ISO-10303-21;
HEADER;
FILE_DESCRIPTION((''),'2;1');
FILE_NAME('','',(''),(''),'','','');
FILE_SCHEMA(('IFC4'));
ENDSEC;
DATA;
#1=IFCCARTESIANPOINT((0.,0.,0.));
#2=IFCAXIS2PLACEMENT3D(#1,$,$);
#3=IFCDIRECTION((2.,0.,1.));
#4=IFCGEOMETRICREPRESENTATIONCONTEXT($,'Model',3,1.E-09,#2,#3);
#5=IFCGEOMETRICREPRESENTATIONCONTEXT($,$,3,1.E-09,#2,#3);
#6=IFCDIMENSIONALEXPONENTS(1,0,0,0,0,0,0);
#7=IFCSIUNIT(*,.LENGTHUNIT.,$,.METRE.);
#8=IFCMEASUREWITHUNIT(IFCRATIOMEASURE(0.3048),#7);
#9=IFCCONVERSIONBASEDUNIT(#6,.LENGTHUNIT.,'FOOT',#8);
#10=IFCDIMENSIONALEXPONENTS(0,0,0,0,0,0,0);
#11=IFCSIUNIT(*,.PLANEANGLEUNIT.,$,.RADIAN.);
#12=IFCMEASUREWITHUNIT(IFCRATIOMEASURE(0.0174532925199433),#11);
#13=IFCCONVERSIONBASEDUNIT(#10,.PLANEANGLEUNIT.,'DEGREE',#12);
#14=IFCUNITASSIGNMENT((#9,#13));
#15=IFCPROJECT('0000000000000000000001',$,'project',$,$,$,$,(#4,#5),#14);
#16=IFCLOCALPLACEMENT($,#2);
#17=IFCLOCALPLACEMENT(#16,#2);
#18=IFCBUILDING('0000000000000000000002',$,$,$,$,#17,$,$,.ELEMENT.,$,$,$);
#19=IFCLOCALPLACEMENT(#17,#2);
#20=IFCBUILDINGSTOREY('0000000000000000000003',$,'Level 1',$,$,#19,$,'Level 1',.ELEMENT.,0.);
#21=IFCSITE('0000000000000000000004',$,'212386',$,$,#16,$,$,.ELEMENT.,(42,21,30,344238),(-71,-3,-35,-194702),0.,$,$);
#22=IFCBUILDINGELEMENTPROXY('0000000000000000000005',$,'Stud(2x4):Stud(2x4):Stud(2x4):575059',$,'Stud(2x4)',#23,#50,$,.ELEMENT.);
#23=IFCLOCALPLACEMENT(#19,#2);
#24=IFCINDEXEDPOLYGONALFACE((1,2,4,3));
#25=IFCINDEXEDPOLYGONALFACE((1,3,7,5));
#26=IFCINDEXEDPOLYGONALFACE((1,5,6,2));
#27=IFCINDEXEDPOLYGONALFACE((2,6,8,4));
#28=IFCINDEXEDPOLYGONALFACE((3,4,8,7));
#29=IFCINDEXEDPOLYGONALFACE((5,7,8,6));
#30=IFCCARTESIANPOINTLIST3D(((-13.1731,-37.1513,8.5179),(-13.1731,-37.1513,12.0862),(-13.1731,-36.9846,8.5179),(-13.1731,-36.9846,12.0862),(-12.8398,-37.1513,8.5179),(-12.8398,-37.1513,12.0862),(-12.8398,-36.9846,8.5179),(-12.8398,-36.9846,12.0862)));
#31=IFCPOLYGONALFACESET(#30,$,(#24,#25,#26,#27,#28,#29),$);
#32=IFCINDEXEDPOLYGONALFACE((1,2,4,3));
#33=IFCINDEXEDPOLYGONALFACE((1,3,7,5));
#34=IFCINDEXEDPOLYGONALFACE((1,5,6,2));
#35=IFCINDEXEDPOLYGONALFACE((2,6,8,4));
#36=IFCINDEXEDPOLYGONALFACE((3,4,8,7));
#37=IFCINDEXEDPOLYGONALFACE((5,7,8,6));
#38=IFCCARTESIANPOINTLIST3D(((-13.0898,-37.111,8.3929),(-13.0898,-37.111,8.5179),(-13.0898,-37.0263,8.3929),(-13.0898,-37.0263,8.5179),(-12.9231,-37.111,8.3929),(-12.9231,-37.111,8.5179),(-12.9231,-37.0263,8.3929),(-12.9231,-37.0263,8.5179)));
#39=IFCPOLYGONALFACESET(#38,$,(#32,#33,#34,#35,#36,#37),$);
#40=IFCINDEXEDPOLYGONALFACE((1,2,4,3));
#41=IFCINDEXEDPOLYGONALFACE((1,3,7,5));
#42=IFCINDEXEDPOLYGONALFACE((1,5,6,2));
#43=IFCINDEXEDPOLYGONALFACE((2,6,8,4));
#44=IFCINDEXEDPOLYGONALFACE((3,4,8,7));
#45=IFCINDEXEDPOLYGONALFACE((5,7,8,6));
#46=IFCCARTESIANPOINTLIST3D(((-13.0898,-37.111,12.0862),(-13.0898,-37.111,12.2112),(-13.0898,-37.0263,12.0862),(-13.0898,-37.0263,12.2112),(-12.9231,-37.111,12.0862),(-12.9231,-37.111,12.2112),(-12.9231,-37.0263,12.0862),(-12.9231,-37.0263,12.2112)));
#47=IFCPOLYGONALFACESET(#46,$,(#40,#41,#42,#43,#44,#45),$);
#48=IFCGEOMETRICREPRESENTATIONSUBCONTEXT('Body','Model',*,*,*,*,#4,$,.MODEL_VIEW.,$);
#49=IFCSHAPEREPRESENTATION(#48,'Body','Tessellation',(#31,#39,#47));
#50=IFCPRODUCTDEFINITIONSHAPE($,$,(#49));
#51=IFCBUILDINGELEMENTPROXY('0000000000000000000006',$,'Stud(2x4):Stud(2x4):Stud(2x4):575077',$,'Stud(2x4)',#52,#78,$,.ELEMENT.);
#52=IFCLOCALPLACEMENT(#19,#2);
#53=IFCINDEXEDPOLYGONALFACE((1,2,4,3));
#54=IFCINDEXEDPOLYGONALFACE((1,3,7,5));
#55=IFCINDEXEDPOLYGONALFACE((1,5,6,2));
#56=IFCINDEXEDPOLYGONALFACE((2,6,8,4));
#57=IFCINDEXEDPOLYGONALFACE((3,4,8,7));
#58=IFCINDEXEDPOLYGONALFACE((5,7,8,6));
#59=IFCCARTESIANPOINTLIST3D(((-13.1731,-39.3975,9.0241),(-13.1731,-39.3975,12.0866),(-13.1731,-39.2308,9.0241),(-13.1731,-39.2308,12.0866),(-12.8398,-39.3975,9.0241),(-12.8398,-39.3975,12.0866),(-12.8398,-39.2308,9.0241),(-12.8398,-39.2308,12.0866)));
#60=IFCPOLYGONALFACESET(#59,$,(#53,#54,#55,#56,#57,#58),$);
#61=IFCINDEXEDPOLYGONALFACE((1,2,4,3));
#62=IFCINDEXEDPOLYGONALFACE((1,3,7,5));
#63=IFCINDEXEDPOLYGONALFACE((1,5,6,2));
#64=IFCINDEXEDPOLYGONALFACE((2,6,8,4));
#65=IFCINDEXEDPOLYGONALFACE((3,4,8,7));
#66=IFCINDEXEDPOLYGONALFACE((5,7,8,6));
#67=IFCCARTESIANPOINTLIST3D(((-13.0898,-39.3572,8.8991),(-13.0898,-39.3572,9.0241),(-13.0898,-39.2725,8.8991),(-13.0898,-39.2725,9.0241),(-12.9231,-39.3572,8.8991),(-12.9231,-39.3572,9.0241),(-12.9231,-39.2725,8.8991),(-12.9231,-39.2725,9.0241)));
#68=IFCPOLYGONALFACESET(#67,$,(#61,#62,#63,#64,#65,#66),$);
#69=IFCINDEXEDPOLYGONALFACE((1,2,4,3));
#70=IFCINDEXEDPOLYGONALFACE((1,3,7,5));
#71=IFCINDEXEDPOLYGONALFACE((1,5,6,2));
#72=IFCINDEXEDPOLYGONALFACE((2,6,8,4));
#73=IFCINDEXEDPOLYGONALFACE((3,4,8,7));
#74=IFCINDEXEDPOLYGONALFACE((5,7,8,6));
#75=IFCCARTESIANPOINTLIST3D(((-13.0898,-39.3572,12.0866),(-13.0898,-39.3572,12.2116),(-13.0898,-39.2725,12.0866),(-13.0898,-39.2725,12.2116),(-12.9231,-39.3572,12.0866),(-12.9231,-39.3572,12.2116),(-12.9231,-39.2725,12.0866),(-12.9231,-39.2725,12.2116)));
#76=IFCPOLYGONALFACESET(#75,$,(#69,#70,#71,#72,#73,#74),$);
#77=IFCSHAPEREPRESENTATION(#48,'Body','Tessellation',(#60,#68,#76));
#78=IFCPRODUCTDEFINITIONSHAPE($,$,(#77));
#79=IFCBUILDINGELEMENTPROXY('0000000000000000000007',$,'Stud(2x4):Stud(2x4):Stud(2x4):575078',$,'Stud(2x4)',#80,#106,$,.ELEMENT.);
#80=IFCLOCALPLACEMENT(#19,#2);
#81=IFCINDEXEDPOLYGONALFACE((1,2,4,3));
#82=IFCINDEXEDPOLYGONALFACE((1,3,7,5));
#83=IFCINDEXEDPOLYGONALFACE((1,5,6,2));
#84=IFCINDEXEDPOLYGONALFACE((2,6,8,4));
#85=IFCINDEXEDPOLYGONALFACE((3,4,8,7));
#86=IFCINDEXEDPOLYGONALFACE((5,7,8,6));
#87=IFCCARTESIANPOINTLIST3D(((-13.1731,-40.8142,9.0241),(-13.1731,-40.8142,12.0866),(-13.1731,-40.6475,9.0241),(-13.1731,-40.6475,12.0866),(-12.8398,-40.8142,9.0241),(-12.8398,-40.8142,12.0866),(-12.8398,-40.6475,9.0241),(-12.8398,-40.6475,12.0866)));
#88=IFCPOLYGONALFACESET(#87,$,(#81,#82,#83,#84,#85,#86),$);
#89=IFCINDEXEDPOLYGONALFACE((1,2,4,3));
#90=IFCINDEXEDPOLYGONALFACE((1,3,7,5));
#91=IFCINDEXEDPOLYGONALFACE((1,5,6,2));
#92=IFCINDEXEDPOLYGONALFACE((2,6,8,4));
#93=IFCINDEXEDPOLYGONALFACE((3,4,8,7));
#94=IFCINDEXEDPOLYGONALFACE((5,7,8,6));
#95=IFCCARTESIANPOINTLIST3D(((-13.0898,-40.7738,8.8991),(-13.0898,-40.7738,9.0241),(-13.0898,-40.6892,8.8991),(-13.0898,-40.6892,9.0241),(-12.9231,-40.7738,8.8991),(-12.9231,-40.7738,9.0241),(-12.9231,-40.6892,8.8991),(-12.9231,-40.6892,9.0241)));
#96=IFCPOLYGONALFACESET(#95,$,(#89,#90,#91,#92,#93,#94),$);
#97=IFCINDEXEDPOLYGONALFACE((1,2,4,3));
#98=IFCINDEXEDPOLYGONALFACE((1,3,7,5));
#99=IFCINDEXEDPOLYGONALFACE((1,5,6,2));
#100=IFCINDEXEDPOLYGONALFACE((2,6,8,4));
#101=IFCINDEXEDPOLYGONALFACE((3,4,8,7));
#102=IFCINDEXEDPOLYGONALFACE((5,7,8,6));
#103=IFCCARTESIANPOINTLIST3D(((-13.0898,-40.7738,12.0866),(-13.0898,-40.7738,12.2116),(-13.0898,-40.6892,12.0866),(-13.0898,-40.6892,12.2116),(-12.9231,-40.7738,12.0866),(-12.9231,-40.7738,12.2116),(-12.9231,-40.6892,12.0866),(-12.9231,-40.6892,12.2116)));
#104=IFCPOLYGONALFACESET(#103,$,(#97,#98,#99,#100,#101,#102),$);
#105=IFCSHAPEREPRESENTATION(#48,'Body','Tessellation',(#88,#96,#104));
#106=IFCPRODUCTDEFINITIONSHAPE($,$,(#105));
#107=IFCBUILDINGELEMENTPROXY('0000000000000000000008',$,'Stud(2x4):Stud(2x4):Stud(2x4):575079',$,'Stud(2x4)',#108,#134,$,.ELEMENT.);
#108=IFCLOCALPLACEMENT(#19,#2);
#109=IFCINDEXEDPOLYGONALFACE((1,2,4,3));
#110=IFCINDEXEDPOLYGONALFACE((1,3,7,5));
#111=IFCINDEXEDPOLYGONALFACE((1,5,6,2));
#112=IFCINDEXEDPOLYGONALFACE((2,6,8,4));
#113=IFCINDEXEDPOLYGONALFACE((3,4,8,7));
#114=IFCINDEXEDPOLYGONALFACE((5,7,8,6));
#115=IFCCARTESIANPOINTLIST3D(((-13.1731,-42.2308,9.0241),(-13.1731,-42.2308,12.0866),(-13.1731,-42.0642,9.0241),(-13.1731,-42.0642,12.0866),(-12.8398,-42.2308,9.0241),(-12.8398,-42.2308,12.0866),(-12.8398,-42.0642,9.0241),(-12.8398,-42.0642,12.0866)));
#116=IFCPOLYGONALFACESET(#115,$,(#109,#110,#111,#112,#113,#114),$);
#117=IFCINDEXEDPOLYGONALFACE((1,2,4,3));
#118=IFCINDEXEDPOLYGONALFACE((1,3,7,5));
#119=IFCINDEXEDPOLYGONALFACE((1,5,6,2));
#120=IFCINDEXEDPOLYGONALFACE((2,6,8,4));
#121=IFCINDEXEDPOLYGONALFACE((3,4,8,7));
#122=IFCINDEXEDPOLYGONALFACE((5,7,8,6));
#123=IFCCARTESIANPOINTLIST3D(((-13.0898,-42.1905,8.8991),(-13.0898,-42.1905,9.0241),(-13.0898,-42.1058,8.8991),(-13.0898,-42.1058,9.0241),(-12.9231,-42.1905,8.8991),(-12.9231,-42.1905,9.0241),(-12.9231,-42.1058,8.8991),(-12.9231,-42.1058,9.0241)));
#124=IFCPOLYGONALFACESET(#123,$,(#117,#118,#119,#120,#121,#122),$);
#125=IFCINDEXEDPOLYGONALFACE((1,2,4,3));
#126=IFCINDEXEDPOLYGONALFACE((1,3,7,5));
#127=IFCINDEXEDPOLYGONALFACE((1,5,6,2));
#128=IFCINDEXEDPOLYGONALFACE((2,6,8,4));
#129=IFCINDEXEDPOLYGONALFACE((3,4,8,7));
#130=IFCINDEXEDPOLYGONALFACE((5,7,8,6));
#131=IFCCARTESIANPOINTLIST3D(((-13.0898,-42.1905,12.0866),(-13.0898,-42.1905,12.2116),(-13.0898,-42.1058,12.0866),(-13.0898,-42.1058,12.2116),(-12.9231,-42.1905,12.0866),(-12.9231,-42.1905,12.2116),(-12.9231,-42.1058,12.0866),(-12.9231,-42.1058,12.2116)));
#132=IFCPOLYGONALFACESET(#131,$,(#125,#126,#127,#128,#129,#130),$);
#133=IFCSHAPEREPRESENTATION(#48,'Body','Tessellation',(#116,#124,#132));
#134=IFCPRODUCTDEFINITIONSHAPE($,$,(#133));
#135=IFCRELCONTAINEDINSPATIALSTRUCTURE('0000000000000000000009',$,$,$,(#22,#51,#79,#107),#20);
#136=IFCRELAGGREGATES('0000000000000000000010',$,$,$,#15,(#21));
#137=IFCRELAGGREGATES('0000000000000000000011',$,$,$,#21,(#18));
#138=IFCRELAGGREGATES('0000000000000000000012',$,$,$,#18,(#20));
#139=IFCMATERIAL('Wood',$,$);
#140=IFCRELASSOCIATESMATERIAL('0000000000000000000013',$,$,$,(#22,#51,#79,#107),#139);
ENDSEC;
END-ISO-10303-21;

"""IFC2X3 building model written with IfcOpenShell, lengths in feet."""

from ifc_helpers import new_model, entity, si_unit, converted_unit, direction, frame, frame_2d, origin, place, context, subcontext, project, spatial, rectangle, extrude, source, transform, mapped, material, element, save


model = new_model("IFC2X3")

# Units and contexts
model_context = context("Model", 3, precision=1e-09, world=origin(), true_north=direction((2.0, 0.0, 1.0)))
context_of_model = context(None, 3, precision=1e-09, world=origin(), true_north=direction((2.0, 0.0, 1.0)))
body_context = subcontext(model_context, "Body", "Model", "MODEL_VIEW")
ifc_project = project(units=[converted_unit("LENGTHUNIT", "FOOT", entity("IfcRatioMeasure", 0.3048), si_unit("LENGTHUNIT", "METRE"), dimensions=[1, 0, 0, 0, 0, 0, 0]), converted_unit("PLANEANGLEUNIT", "DEGREE", entity("IfcRatioMeasure", 0.0174532925199433), si_unit("PLANEANGLEUNIT", "RADIAN"), dimensions=[0, 0, 0, 0, 0, 0, 0])], contexts=[model_context, context_of_model])

# Site, building, storey
site_placement = place(None, origin())
site = spatial("IfcSite", under=ifc_project, at=site_placement, Name="212386", CompositionType="ELEMENT", RefLatitude=(42, 21, 30, 344238), RefLongitude=(-71, -3, -35, -194702), RefElevation=0.0)
building_placement = place(site_placement, origin())
building = spatial("IfcBuilding", under=site, at=building_placement, CompositionType="ELEMENT")
storey_placement = place(building_placement, origin())
storey = spatial("IfcBuildingStorey", under=building, at=storey_placement, Name="Level 1", LongName="Level 1", CompositionType="ELEMENT", Elevation=0.0)

# Building element proxies
ifc_material = material(Name="Wood")
shared_shape_1 = source(origin(), body_context, "Body", "SweptSolid", [
    extrude(rectangle(XDim=0.3333, YDim=0.1667, at=frame_2d((0.0, 0.0), x_axis=(1.0, 0.0))), frame((-13.0064, -37.068, 8.5179), z_axis=(0.0, 0.0, 1.0), x_axis=(-1.0, 0.0, 0.0)), (0.0, 0.0, 1.0), 3.5684),
    extrude(rectangle(XDim=0.1667, YDim=0.0847, at=frame_2d((0.0, 0.0), x_axis=(1.0, 0.0))), frame((-13.0064, -37.0686, 8.3929), z_axis=(0.0, 0.0, 1.0), x_axis=(-1.0, 0.0, 0.0)), (0.0, 0.0, 1.0), 0.125),
    extrude(rectangle(XDim=0.0847, YDim=0.1667, at=frame_2d((0.0, 0.0), x_axis=(1.0, 0.0))), frame((-13.0064, -37.0686, 12.0862), z_axis=(0.0, 0.0, 1.0), x_axis=(0.0, -1.0, 0.0)), (0.0, 0.0, 1.0), 0.125),
])
proxy_1_placement = place(storey_placement, origin())
element("IfcBuildingElementProxy", 1, at=proxy_1_placement, inside=storey, material=ifc_material, Name="Stud(2x4):Stud(2x4):Stud(2x4):575059", ObjectType="Stud(2x4)", CompositionType="ELEMENT", context=body_context, shape_type="MappedRepresentation", body=[
    mapped(shared_shape_1, transform((0.0, 0.0, 0.0), scale=1.0)),
])
shared_shape_2 = source(origin(), body_context, "Body", "SweptSolid", [
    extrude(rectangle(XDim=0.3333, YDim=0.1667, at=frame_2d((0.0, 0.0), x_axis=(1.0, 0.0))), frame((-13.0064, -39.3142, 9.0241), z_axis=(0.0, 0.0, 1.0), x_axis=(-1.0, 0.0, 0.0)), (0.0, 0.0, 1.0), 3.0625),
    extrude(rectangle(XDim=0.1667, YDim=0.0847, at=frame_2d((0.0, 0.0), x_axis=(1.0, 0.0))), frame((-13.0064, -39.3148, 8.8991), z_axis=(0.0, 0.0, 1.0), x_axis=(-1.0, 0.0, 0.0)), (0.0, 0.0, 1.0), 0.125),
    extrude(rectangle(XDim=0.0847, YDim=0.1667, at=frame_2d((0.0, 0.0), x_axis=(1.0, 0.0))), frame((-13.0064, -39.3148, 12.0866), z_axis=(0.0, 0.0, 1.0), x_axis=(0.0, -1.0, 0.0)), (0.0, 0.0, 1.0), 0.125),
])
proxy_2_placement = place(storey_placement, origin())
element("IfcBuildingElementProxy", 2, at=proxy_2_placement, inside=storey, material=ifc_material, Name="Stud(2x4):Stud(2x4):Stud(2x4):575077", ObjectType="Stud(2x4)", CompositionType="ELEMENT", context=body_context, shape_type="MappedRepresentation", body=[
    mapped(shared_shape_2, transform((0.0, 0.0, 0.0), scale=1.0)),
])
shared_shape_3 = source(origin(), body_context, "Body", "SweptSolid", [
    extrude(rectangle(XDim=0.3333, YDim=0.1667, at=frame_2d((0.0, 0.0), x_axis=(1.0, 0.0))), frame((-13.0064, -40.7308, 9.0241), z_axis=(0.0, 0.0, 1.0), x_axis=(-1.0, 0.0, 0.0)), (0.0, 0.0, 1.0), 3.0625),
    extrude(rectangle(XDim=0.1667, YDim=0.0847, at=frame_2d((0.0, 0.0), x_axis=(1.0, 0.0))), frame((-13.0064, -40.7315, 8.8991), z_axis=(0.0, 0.0, 1.0), x_axis=(-1.0, 0.0, 0.0)), (0.0, 0.0, 1.0), 0.125),
    extrude(rectangle(XDim=0.0847, YDim=0.1667, at=frame_2d((0.0, 0.0), x_axis=(1.0, 0.0))), frame((-13.0064, -40.7315, 12.0866), z_axis=(0.0, 0.0, 1.0), x_axis=(0.0, -1.0, 0.0)), (0.0, 0.0, 1.0), 0.125),
])
proxy_3_placement = place(storey_placement, origin())
element("IfcBuildingElementProxy", 3, at=proxy_3_placement, inside=storey, material=ifc_material, Name="Stud(2x4):Stud(2x4):Stud(2x4):575078", ObjectType="Stud(2x4)", CompositionType="ELEMENT", context=body_context, shape_type="MappedRepresentation", body=[
    mapped(shared_shape_3, transform((0.0, 0.0, 0.0), scale=1.0)),
])
shared_shape_4 = source(origin(), body_context, "Body", "SweptSolid", [
    extrude(rectangle(XDim=0.3333, YDim=0.1667, at=frame_2d((0.0, 0.0), x_axis=(1.0, 0.0))), frame((-13.0064, -42.1475, 9.0241), z_axis=(0.0, 0.0, 1.0), x_axis=(-1.0, 0.0, 0.0)), (0.0, 0.0, 1.0), 3.0625),
    extrude(rectangle(XDim=0.1667, YDim=0.0847, at=frame_2d((0.0, 0.0), x_axis=(1.0, 0.0))), frame((-13.0064, -42.1482, 8.8991), z_axis=(0.0, 0.0, 1.0), x_axis=(-1.0, 0.0, 0.0)), (0.0, 0.0, 1.0), 0.125),
    extrude(rectangle(XDim=0.0847, YDim=0.1667, at=frame_2d((0.0, 0.0), x_axis=(1.0, 0.0))), frame((-13.0064, -42.1482, 12.0866), z_axis=(0.0, 0.0, 1.0), x_axis=(0.0, -1.0, 0.0)), (0.0, 0.0, 1.0), 0.125),
])
proxy_4_placement = place(storey_placement, origin())
element("IfcBuildingElementProxy", 4, at=proxy_4_placement, inside=storey, material=ifc_material, Name="Stud(2x4):Stud(2x4):Stud(2x4):575079", ObjectType="Stud(2x4)", CompositionType="ELEMENT", context=body_context, shape_type="MappedRepresentation", body=[
    mapped(shared_shape_4, transform((0.0, 0.0, 0.0), scale=1.0)),
])

save(model, "model.ifc")
